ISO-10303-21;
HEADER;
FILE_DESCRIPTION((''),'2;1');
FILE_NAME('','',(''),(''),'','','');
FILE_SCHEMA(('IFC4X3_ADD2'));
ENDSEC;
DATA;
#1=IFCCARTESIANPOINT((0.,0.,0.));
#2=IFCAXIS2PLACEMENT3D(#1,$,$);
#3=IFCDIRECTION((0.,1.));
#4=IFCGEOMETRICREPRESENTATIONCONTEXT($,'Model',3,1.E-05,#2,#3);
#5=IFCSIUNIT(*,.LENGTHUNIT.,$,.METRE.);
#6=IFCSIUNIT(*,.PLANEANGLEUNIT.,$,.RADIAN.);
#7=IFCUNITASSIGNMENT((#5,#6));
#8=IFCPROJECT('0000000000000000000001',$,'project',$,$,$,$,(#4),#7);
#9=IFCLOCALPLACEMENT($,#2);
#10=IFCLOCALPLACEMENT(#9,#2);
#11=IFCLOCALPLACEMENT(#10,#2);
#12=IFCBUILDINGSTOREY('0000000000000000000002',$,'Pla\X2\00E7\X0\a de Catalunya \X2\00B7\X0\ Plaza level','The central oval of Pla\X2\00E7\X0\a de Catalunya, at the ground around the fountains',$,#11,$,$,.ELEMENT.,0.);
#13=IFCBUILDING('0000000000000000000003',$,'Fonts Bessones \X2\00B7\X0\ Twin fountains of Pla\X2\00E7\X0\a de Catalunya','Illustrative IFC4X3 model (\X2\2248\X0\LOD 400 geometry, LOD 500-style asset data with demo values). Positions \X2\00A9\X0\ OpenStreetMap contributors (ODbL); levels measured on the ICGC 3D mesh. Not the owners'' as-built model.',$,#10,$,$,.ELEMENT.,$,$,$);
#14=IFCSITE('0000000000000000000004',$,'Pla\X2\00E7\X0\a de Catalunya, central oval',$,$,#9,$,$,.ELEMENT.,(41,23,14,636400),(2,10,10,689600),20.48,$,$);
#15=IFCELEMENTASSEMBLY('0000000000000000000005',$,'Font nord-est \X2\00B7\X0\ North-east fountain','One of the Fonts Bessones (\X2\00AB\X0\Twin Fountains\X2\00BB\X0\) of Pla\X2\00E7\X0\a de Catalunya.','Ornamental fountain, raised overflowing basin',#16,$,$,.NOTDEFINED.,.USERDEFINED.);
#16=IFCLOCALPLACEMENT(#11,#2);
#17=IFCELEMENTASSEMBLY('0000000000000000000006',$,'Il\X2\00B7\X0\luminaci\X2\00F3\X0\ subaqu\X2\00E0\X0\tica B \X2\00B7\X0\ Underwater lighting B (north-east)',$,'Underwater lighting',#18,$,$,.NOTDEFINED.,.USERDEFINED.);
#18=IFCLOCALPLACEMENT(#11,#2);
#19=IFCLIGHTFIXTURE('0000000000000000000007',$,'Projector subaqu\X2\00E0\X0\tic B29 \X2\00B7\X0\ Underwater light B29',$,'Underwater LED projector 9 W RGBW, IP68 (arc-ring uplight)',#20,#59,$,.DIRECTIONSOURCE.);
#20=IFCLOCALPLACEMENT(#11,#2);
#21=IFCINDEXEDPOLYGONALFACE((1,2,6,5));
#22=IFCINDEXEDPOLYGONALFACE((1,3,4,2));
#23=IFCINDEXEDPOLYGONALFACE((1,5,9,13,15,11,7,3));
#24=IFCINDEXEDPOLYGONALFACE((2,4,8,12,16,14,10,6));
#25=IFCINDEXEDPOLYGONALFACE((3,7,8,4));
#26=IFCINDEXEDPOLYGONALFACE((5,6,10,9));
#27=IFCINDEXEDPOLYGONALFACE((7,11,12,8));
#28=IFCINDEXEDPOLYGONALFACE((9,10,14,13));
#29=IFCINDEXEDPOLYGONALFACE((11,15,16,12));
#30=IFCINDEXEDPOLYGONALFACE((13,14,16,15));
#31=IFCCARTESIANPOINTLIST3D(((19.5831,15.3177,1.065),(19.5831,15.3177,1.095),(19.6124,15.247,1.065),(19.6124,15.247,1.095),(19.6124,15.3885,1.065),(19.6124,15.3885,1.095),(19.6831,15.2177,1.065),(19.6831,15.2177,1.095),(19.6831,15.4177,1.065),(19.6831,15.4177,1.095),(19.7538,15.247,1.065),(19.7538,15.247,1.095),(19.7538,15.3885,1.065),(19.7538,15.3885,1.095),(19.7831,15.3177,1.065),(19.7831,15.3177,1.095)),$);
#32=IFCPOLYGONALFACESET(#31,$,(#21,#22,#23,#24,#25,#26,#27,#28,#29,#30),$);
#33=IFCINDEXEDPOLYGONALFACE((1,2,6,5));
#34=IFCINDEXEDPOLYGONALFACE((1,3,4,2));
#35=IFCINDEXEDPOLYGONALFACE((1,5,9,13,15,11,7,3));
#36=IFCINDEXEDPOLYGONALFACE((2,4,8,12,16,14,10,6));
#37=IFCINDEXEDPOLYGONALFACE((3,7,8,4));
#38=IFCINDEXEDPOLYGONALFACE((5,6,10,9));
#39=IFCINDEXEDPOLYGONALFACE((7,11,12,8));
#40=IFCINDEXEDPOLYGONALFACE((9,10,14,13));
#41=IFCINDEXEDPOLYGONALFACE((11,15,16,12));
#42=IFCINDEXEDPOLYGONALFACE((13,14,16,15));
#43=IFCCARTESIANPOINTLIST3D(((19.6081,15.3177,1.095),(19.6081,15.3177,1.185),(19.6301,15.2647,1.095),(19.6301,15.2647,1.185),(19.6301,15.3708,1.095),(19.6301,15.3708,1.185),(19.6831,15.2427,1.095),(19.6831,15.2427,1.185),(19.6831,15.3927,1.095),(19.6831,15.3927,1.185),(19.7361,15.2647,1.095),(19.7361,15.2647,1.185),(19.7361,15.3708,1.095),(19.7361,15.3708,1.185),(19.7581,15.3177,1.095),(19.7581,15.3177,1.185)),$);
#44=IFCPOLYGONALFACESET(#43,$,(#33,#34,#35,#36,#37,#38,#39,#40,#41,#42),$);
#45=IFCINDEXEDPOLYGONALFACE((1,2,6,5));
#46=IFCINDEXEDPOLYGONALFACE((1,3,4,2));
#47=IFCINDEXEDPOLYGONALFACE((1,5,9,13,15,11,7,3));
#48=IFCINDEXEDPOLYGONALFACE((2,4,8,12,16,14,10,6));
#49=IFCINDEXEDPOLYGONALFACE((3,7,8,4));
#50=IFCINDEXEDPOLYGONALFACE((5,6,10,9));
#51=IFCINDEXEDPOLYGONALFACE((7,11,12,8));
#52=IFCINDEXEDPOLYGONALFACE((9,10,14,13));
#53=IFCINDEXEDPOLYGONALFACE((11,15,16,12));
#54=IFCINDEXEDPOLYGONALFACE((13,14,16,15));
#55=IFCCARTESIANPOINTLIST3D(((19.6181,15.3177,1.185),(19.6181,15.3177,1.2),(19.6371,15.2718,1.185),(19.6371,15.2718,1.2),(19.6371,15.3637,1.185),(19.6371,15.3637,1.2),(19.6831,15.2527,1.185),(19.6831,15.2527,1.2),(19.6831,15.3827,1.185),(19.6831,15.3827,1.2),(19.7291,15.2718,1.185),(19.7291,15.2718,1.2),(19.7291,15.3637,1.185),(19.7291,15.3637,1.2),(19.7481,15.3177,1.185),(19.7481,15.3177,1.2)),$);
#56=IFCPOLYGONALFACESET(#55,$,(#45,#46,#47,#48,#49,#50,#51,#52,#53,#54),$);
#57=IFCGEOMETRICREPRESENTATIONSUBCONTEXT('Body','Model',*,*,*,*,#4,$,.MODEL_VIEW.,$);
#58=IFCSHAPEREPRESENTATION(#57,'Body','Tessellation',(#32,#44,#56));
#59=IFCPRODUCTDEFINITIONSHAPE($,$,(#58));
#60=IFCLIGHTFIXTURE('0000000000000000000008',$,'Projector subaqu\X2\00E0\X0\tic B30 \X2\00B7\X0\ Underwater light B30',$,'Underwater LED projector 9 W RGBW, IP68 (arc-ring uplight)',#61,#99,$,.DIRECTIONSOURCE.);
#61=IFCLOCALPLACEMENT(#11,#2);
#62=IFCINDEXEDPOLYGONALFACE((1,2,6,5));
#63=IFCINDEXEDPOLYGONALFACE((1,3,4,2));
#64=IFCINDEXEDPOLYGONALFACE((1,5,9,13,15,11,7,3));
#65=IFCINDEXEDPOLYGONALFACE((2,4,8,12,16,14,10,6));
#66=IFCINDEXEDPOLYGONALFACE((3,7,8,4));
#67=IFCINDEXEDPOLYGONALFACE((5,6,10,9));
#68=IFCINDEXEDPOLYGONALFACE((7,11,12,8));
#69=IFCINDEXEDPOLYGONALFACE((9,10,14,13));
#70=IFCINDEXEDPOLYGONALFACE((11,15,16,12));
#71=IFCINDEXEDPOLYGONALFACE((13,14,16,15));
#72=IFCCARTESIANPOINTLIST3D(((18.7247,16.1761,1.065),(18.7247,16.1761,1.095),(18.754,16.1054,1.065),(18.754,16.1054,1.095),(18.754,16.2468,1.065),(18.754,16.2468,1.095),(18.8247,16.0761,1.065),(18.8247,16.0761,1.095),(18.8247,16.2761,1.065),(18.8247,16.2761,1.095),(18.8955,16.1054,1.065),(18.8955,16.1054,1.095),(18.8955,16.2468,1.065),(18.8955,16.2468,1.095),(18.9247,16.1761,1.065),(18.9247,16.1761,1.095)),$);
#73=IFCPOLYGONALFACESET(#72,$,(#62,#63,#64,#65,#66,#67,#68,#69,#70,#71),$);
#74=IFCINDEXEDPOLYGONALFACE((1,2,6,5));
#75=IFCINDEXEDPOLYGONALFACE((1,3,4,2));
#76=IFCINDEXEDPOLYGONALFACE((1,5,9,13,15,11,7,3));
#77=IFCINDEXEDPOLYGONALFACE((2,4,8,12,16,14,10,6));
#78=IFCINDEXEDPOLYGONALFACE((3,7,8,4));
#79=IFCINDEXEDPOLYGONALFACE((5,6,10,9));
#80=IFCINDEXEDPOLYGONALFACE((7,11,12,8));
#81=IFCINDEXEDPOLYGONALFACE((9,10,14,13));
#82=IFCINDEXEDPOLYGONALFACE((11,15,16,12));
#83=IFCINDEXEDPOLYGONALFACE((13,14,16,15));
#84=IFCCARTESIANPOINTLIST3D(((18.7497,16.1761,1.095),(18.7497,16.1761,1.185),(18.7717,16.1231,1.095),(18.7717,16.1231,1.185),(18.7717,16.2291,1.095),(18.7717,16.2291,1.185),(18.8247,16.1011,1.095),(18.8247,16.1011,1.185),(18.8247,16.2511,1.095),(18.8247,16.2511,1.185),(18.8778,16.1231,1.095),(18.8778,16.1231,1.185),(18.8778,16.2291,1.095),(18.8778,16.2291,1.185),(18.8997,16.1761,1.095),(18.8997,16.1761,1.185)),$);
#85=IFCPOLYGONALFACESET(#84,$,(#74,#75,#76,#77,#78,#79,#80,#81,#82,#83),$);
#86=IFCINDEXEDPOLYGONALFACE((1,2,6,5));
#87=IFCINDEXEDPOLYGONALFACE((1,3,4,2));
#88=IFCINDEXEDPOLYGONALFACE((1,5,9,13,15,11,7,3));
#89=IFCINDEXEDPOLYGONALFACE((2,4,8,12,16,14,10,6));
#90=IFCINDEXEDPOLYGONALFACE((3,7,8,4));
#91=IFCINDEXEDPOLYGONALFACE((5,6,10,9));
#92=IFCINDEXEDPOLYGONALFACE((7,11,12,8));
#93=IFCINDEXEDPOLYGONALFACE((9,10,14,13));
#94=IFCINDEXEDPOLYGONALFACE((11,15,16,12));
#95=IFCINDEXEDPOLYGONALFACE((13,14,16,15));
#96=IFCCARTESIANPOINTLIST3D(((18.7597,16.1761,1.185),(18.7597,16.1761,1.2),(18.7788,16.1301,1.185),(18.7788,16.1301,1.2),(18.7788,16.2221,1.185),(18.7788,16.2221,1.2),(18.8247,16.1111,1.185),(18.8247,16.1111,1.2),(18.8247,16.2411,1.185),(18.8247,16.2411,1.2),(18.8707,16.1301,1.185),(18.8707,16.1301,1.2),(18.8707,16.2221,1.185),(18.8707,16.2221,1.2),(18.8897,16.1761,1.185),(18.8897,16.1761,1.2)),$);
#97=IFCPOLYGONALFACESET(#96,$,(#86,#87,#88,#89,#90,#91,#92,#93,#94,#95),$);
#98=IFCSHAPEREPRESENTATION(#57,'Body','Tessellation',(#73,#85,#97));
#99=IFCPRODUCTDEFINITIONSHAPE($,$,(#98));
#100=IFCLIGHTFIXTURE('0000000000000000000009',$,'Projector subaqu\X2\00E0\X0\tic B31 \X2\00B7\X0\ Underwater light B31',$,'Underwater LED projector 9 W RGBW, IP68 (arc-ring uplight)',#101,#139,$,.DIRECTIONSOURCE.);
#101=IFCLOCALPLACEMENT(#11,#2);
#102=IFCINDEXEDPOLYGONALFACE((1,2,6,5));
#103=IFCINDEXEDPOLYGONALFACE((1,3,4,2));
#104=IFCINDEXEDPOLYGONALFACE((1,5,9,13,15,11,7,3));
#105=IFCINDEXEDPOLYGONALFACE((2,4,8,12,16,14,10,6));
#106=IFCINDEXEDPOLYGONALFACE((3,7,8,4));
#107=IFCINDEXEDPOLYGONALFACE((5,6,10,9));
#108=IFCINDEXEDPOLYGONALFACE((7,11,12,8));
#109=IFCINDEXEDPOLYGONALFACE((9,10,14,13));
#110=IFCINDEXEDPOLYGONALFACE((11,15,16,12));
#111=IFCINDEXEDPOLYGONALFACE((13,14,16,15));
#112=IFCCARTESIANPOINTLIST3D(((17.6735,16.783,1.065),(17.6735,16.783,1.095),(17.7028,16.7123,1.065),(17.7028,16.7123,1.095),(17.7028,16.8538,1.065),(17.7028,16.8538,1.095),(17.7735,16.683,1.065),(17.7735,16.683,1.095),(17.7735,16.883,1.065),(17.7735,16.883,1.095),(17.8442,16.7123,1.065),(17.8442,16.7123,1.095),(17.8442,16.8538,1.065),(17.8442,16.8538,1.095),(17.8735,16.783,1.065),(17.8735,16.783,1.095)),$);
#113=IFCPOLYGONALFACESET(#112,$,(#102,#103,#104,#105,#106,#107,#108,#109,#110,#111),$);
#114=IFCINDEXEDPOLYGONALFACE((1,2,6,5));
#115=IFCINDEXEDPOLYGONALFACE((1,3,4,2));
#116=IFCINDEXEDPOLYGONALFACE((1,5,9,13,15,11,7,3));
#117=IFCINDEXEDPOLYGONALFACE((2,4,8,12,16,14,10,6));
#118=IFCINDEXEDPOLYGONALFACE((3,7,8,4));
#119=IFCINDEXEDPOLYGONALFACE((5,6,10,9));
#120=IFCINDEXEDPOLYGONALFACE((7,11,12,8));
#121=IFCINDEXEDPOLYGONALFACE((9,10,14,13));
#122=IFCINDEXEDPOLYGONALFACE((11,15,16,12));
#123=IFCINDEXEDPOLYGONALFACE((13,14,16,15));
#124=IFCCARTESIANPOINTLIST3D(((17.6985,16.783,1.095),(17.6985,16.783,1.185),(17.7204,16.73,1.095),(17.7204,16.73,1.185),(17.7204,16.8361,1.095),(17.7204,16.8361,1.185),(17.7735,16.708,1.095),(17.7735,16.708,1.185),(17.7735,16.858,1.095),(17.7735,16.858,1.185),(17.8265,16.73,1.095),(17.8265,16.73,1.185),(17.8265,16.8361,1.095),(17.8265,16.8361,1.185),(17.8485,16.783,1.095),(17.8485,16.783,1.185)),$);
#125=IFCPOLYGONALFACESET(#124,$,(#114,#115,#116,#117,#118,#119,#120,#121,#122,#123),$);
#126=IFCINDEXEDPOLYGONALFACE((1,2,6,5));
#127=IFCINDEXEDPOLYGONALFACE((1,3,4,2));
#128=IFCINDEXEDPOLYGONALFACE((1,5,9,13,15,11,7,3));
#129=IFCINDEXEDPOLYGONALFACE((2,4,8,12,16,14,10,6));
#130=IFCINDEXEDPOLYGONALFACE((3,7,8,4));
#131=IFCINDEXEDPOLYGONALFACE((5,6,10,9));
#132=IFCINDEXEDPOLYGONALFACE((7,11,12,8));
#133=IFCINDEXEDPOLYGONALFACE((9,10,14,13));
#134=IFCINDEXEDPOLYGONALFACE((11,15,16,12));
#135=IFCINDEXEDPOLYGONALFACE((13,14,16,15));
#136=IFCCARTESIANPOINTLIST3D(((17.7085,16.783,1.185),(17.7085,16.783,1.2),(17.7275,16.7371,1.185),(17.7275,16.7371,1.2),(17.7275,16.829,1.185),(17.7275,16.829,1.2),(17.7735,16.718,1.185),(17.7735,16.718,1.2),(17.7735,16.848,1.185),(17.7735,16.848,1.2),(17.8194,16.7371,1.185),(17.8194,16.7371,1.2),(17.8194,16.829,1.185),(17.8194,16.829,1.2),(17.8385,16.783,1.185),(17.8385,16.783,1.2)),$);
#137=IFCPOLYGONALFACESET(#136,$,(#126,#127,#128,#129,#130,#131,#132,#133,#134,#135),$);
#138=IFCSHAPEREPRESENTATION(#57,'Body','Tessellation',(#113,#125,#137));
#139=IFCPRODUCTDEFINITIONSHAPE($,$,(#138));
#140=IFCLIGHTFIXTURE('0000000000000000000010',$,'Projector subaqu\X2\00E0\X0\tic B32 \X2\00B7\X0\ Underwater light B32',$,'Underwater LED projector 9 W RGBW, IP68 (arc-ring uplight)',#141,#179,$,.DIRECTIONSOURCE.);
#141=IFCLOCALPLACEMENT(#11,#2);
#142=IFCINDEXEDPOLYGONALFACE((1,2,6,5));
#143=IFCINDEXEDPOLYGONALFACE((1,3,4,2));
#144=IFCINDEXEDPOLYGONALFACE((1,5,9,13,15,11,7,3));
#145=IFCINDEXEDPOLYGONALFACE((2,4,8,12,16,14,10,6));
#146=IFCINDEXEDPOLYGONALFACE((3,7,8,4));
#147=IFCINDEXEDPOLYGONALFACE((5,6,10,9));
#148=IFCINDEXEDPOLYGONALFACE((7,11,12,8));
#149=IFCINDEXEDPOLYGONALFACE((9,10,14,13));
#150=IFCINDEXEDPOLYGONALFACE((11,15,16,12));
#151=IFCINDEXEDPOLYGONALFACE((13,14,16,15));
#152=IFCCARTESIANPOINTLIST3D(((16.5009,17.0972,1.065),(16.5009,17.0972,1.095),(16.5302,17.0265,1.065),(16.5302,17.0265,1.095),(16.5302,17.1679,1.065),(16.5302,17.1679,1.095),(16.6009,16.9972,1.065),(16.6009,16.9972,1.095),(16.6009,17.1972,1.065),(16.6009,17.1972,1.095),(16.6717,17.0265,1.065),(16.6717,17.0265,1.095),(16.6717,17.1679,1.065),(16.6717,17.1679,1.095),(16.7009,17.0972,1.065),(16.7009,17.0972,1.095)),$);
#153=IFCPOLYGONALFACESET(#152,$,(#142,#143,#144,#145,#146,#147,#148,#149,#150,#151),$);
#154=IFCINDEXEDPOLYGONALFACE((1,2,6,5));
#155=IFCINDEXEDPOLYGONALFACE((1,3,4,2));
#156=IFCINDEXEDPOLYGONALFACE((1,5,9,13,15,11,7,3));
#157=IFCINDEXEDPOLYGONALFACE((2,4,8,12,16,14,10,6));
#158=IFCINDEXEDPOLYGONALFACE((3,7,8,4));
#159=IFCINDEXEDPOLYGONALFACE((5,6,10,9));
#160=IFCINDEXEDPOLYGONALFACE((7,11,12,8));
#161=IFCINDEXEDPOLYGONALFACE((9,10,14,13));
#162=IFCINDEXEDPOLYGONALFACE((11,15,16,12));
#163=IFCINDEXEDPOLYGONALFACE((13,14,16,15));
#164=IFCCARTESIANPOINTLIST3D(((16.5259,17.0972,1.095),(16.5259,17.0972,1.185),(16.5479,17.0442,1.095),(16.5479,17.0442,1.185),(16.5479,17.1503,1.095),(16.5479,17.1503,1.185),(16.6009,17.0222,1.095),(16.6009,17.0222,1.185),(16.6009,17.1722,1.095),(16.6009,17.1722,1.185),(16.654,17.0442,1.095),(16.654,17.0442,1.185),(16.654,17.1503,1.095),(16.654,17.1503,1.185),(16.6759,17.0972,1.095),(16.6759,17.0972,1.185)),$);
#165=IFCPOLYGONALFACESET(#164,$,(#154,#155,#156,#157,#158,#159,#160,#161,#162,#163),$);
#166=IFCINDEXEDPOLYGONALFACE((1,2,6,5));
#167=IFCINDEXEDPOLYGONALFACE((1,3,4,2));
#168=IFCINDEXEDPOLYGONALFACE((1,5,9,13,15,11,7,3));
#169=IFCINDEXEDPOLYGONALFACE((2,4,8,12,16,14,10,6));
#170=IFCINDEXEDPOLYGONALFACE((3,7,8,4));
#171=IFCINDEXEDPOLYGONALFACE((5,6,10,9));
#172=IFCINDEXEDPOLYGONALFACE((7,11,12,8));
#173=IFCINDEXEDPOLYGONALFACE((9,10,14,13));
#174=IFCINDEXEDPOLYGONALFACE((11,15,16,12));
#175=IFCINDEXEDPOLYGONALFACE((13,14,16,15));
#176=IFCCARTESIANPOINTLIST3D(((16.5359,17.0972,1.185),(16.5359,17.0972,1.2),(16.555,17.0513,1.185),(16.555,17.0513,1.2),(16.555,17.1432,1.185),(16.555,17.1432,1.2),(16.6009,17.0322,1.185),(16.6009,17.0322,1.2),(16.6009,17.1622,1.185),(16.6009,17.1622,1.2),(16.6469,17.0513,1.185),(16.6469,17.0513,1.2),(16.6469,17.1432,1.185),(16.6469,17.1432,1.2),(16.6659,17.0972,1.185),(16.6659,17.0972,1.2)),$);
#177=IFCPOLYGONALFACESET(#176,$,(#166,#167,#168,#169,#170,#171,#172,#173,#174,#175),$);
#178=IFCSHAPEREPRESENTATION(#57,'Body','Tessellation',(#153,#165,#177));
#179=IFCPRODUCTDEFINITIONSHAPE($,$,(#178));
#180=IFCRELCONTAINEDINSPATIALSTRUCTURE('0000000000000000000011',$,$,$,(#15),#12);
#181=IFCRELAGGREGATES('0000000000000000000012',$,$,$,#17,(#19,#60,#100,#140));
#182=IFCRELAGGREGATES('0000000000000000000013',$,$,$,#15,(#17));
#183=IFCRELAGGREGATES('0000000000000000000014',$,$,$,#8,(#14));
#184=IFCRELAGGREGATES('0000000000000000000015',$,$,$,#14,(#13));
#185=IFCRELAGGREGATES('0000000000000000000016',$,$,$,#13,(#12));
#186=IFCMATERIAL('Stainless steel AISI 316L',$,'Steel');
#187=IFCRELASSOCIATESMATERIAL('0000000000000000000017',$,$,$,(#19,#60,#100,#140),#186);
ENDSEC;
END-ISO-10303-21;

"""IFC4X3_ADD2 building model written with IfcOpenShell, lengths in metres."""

from ifc_helpers import new_model, si_unit, direction, frame, origin, place, context, subcontext, project, spatial, polyline, outline, extrude, material, element, aggregate, save


model = new_model("IFC4X3_ADD2")

# Units and contexts
model_context = context("Model", 3, precision=1e-05, world=origin(), true_north=direction((0.0, 1.0)))
body_context = subcontext(model_context, "Body", "Model", "MODEL_VIEW")
ifc_project = project(units=[si_unit("LENGTHUNIT", "METRE"), si_unit("PLANEANGLEUNIT", "RADIAN")], contexts=[model_context])

# Site, building, storey
site_placement = place(None, origin())
site = spatial("IfcSite", under=ifc_project, at=site_placement, Name="Plaça de Catalunya, central oval", CompositionType="ELEMENT", RefLatitude=(41, 23, 14, 636400), RefLongitude=(2, 10, 10, 689600), RefElevation=20.48)
building_placement = place(site_placement, origin())
building = spatial("IfcBuilding", under=site, at=building_placement, Name="Fonts Bessones · Twin fountains of Plaça de Catalunya", Description="Illustrative IFC4X3 model (≈LOD 400 geometry, LOD 500-style asset data with demo values). Positions © OpenStreetMap contributors (ODbL); levels measured on the ICGC 3D mesh. Not the owners' as-built model.", CompositionType="ELEMENT")
storey_placement = place(building_placement, origin())
storey = spatial("IfcBuildingStorey", under=building, at=storey_placement, Name="Plaça de Catalunya · Plaza level", Description="The central oval of Plaça de Catalunya, at the ground around the fountains", CompositionType="ELEMENT", Elevation=0.0)

# Element assemblies, light fixtures
assembly_1_placement = place(building_placement, origin())
assembly_1 = element("IfcElementAssembly", 1, at=assembly_1_placement, inside=storey, Name="Font nord-est · North-east fountain", Description="One of the Fonts Bessones («Twin Fountains») of Plaça de Catalunya.", ObjectType="Ornamental fountain, raised overflowing basin", AssemblyPlace="NOTDEFINED", PredefinedType="USERDEFINED")
assembly_2_placement = place(building_placement, origin())
assembly_2 = element("IfcElementAssembly", 2, at=assembly_2_placement, Name="Il·luminació subaquàtica B · Underwater lighting B (north-east)", ObjectType="Underwater lighting", AssemblyPlace="NOTDEFINED", PredefinedType="USERDEFINED")
ifc_material_1 = material(Name="Stainless steel AISI 316L", Category="Steel")
light_fixture_1_placement = place(building_placement, origin())
light_fixture_1 = element("IfcLightFixture", 3, at=light_fixture_1_placement, material=ifc_material_1, Name="Projector subaquàtic B29 · Underwater light B29", ObjectType="Underwater LED projector 9 W RGBW, IP68 (arc-ring uplight)", PredefinedType="DIRECTIONSOURCE", context=body_context, shape_type="SweptSolid", body=[
    extrude(outline(polyline([(19.7831, 15.3177), (19.7538, 15.3885), (19.6831, 15.4177), (19.6124, 15.3885), (19.5831, 15.3177), (19.6124, 15.247), (19.6831, 15.2177), (19.7538, 15.247), (19.7831, 15.3177)])), frame((0.0, 0.0, 1.065)), (0.0, 0.0, 1.0), 0.03),
    extrude(outline(polyline([(19.7581, 15.3177), (19.7361, 15.3708), (19.6831, 15.3927), (19.6301, 15.3708), (19.6081, 15.3177), (19.6301, 15.2647), (19.6831, 15.2427), (19.7361, 15.2647), (19.7581, 15.3177)])), frame((0.0, 0.0, 1.095)), (0.0, 0.0, 1.0), 0.09),
    extrude(outline(polyline([(19.7481, 15.3177), (19.7291, 15.3637), (19.6831, 15.3827), (19.6371, 15.3637), (19.6181, 15.3177), (19.6371, 15.2718), (19.6831, 15.2527), (19.7291, 15.2718), (19.7481, 15.3177)])), frame((0.0, 0.0, 1.185)), (0.0, 0.0, 1.0), 0.015),
])
light_fixture_2_placement = place(building_placement, origin())
light_fixture_2 = element("IfcLightFixture", 4, at=light_fixture_2_placement, material=ifc_material_1, Name="Projector subaquàtic B30 · Underwater light B30", ObjectType="Underwater LED projector 9 W RGBW, IP68 (arc-ring uplight)", PredefinedType="DIRECTIONSOURCE", context=body_context, shape_type="SweptSolid", body=[
    extrude(outline(polyline([(18.9247, 16.1761), (18.8955, 16.2468), (18.8247, 16.2761), (18.754, 16.2468), (18.7247, 16.1761), (18.754, 16.1054), (18.8247, 16.0761), (18.8955, 16.1054), (18.9247, 16.1761)])), frame((0.0, 0.0, 1.065)), (0.0, 0.0, 1.0), 0.03),
    extrude(outline(polyline([(18.8997, 16.1761), (18.8778, 16.2291), (18.8247, 16.2511), (18.7717, 16.2291), (18.7497, 16.1761), (18.7717, 16.1231), (18.8247, 16.1011), (18.8778, 16.1231), (18.8997, 16.1761)])), frame((0.0, 0.0, 1.095)), (0.0, 0.0, 1.0), 0.09),
    extrude(outline(polyline([(18.8897, 16.1761), (18.8707, 16.2221), (18.8247, 16.2411), (18.7788, 16.2221), (18.7597, 16.1761), (18.7788, 16.1301), (18.8247, 16.1111), (18.8707, 16.1301), (18.8897, 16.1761)])), frame((0.0, 0.0, 1.185)), (0.0, 0.0, 1.0), 0.015),
])
light_fixture_3_placement = place(building_placement, origin())
light_fixture_3 = element("IfcLightFixture", 5, at=light_fixture_3_placement, material=ifc_material_1, Name="Projector subaquàtic B31 · Underwater light B31", ObjectType="Underwater LED projector 9 W RGBW, IP68 (arc-ring uplight)", PredefinedType="DIRECTIONSOURCE", context=body_context, shape_type="SweptSolid", body=[
    extrude(outline(polyline([(17.8735, 16.783), (17.8442, 16.8538), (17.7735, 16.883), (17.7028, 16.8538), (17.6735, 16.783), (17.7028, 16.7123), (17.7735, 16.683), (17.8442, 16.7123), (17.8735, 16.783)])), frame((0.0, 0.0, 1.065)), (0.0, 0.0, 1.0), 0.03),
    extrude(outline(polyline([(17.8485, 16.783), (17.8265, 16.8361), (17.7735, 16.858), (17.7204, 16.8361), (17.6985, 16.783), (17.7204, 16.73), (17.7735, 16.708), (17.8265, 16.73), (17.8485, 16.783)])), frame((0.0, 0.0, 1.095)), (0.0, 0.0, 1.0), 0.09),
    extrude(outline(polyline([(17.8385, 16.783), (17.8194, 16.829), (17.7735, 16.848), (17.7275, 16.829), (17.7085, 16.783), (17.7275, 16.7371), (17.7735, 16.718), (17.8194, 16.7371), (17.8385, 16.783)])), frame((0.0, 0.0, 1.185)), (0.0, 0.0, 1.0), 0.015),
])
light_fixture_4_placement = place(building_placement, origin())
light_fixture_4 = element("IfcLightFixture", 6, at=light_fixture_4_placement, material=ifc_material_1, Name="Projector subaquàtic B32 · Underwater light B32", ObjectType="Underwater LED projector 9 W RGBW, IP68 (arc-ring uplight)", PredefinedType="DIRECTIONSOURCE", context=body_context, shape_type="SweptSolid", body=[
    extrude(outline(polyline([(16.7009, 17.0972), (16.6717, 17.1679), (16.6009, 17.1972), (16.5302, 17.1679), (16.5009, 17.0972), (16.5302, 17.0265), (16.6009, 16.9972), (16.6717, 17.0265), (16.7009, 17.0972)])), frame((0.0, 0.0, 1.065)), (0.0, 0.0, 1.0), 0.03),
    extrude(outline(polyline([(16.6759, 17.0972), (16.654, 17.1503), (16.6009, 17.1722), (16.5479, 17.1503), (16.5259, 17.0972), (16.5479, 17.0442), (16.6009, 17.0222), (16.654, 17.0442), (16.6759, 17.0972)])), frame((0.0, 0.0, 1.095)), (0.0, 0.0, 1.0), 0.09),
    extrude(outline(polyline([(16.6659, 17.0972), (16.6469, 17.1432), (16.6009, 17.1622), (16.555, 17.1432), (16.5359, 17.0972), (16.555, 17.0513), (16.6009, 17.0322), (16.6469, 17.0513), (16.6659, 17.0972)])), frame((0.0, 0.0, 1.185)), (0.0, 0.0, 1.0), 0.015),
])
aggregate(assembly_2, [light_fixture_1, light_fixture_2, light_fixture_3, light_fixture_4])
aggregate(assembly_1, [assembly_2])

save(model, "model.ifc")
